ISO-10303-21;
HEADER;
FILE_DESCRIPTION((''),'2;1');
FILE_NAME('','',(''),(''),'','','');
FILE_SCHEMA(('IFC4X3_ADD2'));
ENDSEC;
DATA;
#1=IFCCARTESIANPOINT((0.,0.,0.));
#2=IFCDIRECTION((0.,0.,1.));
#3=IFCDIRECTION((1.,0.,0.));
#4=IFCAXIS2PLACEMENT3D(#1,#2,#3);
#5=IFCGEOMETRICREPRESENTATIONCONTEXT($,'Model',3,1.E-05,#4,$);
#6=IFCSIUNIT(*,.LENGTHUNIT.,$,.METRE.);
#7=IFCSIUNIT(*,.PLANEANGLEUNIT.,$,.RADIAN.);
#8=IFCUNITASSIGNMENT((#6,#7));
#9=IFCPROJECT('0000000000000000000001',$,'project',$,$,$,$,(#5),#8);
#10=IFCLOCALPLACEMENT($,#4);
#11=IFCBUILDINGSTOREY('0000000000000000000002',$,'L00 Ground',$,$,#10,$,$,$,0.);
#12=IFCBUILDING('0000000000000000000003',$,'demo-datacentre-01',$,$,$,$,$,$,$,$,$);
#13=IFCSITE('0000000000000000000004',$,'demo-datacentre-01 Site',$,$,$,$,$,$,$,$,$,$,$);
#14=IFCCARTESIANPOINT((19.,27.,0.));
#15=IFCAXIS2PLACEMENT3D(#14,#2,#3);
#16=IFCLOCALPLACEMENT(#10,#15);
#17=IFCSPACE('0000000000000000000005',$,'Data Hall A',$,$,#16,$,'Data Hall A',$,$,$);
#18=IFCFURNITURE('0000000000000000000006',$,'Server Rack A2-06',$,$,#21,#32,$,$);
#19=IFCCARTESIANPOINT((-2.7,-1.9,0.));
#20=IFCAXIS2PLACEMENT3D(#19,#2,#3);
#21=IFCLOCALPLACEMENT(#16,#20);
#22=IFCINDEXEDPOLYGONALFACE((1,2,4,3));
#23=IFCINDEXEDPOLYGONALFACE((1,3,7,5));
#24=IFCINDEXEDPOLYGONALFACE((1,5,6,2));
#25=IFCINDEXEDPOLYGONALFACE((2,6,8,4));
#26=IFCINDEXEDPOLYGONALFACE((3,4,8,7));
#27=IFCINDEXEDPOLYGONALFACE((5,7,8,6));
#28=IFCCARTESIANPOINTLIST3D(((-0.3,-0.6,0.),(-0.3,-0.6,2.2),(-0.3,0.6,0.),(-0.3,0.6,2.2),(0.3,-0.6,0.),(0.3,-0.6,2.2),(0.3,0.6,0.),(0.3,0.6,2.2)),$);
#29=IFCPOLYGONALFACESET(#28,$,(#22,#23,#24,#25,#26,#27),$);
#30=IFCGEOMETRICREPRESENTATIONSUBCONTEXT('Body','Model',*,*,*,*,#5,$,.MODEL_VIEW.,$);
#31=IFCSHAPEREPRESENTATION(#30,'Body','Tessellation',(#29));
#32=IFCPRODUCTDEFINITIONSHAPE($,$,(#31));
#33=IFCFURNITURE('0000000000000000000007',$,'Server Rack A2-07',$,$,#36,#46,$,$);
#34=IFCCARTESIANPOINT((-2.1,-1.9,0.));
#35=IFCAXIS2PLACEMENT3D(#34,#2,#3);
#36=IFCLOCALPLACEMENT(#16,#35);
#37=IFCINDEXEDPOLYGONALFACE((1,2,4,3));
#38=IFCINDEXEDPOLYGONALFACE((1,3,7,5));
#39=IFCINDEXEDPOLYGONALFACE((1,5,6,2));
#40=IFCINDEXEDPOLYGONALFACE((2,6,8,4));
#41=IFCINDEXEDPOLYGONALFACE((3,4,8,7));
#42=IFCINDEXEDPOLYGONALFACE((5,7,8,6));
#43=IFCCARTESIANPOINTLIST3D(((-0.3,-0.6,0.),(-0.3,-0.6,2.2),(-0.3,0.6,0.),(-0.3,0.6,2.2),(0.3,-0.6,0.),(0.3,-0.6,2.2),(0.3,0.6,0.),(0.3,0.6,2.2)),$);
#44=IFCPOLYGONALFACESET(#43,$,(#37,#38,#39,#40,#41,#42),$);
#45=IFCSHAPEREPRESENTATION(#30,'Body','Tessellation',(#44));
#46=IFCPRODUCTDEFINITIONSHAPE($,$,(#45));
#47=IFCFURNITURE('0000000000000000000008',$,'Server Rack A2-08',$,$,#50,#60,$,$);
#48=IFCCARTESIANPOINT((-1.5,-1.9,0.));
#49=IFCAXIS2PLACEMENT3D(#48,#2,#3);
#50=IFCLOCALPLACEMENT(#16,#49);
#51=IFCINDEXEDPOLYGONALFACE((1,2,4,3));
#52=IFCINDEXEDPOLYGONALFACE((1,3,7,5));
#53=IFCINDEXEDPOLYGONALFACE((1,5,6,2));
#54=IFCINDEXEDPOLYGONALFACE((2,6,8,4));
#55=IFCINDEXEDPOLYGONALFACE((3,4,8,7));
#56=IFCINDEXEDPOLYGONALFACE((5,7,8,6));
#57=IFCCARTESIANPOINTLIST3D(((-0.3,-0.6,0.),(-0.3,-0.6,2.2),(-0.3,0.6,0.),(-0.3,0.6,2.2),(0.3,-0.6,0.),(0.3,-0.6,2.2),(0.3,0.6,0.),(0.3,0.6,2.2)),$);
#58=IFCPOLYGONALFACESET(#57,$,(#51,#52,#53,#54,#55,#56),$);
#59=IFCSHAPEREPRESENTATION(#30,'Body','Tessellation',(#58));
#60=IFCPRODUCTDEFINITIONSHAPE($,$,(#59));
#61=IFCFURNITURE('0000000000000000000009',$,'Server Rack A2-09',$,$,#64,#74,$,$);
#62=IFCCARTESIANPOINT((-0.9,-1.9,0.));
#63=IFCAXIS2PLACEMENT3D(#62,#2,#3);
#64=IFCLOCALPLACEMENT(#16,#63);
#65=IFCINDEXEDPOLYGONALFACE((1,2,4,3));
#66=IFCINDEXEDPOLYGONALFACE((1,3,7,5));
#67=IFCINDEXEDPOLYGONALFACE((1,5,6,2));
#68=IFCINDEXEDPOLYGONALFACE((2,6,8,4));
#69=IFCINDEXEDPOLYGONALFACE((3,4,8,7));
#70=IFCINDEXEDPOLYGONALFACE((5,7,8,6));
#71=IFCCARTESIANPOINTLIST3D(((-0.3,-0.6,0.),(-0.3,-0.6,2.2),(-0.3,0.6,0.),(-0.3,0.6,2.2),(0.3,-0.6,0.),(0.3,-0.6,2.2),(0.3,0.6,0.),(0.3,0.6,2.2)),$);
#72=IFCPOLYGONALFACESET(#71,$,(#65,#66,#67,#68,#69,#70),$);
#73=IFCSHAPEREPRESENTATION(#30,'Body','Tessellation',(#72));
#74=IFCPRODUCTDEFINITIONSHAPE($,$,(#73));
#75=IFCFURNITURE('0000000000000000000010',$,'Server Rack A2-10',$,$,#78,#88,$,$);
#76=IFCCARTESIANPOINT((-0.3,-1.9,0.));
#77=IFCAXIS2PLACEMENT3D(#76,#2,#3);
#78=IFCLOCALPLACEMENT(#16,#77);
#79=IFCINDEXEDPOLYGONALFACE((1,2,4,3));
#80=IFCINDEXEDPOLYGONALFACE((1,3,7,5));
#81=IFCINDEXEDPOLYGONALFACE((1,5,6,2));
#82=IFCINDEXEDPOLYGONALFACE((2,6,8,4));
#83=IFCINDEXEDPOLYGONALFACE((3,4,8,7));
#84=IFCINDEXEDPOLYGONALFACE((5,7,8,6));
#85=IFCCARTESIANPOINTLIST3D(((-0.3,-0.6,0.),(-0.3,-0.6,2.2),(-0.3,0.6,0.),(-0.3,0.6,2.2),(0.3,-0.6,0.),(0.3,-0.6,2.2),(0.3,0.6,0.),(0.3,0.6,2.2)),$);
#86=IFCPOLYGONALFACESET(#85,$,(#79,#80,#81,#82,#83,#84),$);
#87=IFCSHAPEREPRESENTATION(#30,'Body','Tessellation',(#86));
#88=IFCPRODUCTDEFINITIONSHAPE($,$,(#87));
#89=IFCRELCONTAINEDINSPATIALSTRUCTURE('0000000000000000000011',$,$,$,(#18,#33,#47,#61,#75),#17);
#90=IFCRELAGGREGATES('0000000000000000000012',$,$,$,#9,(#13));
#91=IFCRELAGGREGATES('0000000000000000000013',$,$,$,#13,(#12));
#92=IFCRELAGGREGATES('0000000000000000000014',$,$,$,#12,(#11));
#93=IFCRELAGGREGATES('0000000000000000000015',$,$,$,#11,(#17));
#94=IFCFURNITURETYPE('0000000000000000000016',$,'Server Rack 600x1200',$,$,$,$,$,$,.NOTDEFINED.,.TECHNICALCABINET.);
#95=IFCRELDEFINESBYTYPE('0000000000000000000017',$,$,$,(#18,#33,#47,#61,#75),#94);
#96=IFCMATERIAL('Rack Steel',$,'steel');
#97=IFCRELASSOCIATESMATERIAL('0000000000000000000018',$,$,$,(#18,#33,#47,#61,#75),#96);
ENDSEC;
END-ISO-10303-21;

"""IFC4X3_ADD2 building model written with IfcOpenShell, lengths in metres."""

from ifc_helpers import new_model, si_unit, frame, origin_with_axes, place, context, subcontext, project, spatial, rectangle, extrude, material, type_object, element, save


model = new_model("IFC4X3_ADD2")

# Units and contexts
model_context = context("Model", 3, precision=1e-05, world=origin_with_axes())
body_context = subcontext(model_context, "Body", "Model", "MODEL_VIEW")
ifc_project = project(units=[si_unit("LENGTHUNIT", "METRE"), si_unit("PLANEANGLEUNIT", "RADIAN")], contexts=[model_context])

# Site, building, storey
site = spatial("IfcSite", under=ifc_project, Name="demo-datacentre-01 Site")
building = spatial("IfcBuilding", under=site, Name="demo-datacentre-01")
storey_placement = place(None, origin_with_axes())
storey = spatial("IfcBuildingStorey", under=building, at=storey_placement, Name="L00 Ground", Elevation=0.0)

# Shared definitions
space_placement = place(storey_placement, frame((19.0, 27.0, 0.0), z_axis=(0.0, 0.0, 1.0), x_axis=(1.0, 0.0, 0.0)))
space = spatial("IfcSpace", under=storey, at=space_placement, Name="Data Hall A", LongName="Data Hall A")

# Furniture
ifc_material_1 = material(Name="Rack Steel", Category="steel")
furniture_type = type_object("IfcFurnitureType", Name="Server Rack 600x1200", AssemblyPlace="NOTDEFINED", PredefinedType="TECHNICALCABINET")
for number, where, z_axis, x_axis, name in (
    (1, (-2.7, -1.9, 0.0), (0.0, 0.0, 1.0), (1.0, 0.0, 0.0), "Server Rack A2-06"),
    (2, (-2.1, -1.9, 0.0), (0.0, 0.0, 1.0), (1.0, 0.0, 0.0), "Server Rack A2-07"),
    (3, (-1.5, -1.9, 0.0), (0.0, 0.0, 1.0), (1.0, 0.0, 0.0), "Server Rack A2-08"),
    (4, (-0.9, -1.9, 0.0), (0.0, 0.0, 1.0), (1.0, 0.0, 0.0), "Server Rack A2-09"),
    (5, (-0.3, -1.9, 0.0), (0.0, 0.0, 1.0), (1.0, 0.0, 0.0), "Server Rack A2-10"),
):
    element("IfcFurniture", number, at=place(space_placement, frame(where, z_axis=z_axis, x_axis=x_axis)), inside=space, type_object=furniture_type, material=ifc_material_1, Name=name, context=body_context, shape_type="SweptSolid", body=[
        extrude(rectangle(XDim=0.6, YDim=1.2), origin_with_axes(), (0.0, 0.0, 1.0), 2.2),
    ])

save(model, "model.ifc")
